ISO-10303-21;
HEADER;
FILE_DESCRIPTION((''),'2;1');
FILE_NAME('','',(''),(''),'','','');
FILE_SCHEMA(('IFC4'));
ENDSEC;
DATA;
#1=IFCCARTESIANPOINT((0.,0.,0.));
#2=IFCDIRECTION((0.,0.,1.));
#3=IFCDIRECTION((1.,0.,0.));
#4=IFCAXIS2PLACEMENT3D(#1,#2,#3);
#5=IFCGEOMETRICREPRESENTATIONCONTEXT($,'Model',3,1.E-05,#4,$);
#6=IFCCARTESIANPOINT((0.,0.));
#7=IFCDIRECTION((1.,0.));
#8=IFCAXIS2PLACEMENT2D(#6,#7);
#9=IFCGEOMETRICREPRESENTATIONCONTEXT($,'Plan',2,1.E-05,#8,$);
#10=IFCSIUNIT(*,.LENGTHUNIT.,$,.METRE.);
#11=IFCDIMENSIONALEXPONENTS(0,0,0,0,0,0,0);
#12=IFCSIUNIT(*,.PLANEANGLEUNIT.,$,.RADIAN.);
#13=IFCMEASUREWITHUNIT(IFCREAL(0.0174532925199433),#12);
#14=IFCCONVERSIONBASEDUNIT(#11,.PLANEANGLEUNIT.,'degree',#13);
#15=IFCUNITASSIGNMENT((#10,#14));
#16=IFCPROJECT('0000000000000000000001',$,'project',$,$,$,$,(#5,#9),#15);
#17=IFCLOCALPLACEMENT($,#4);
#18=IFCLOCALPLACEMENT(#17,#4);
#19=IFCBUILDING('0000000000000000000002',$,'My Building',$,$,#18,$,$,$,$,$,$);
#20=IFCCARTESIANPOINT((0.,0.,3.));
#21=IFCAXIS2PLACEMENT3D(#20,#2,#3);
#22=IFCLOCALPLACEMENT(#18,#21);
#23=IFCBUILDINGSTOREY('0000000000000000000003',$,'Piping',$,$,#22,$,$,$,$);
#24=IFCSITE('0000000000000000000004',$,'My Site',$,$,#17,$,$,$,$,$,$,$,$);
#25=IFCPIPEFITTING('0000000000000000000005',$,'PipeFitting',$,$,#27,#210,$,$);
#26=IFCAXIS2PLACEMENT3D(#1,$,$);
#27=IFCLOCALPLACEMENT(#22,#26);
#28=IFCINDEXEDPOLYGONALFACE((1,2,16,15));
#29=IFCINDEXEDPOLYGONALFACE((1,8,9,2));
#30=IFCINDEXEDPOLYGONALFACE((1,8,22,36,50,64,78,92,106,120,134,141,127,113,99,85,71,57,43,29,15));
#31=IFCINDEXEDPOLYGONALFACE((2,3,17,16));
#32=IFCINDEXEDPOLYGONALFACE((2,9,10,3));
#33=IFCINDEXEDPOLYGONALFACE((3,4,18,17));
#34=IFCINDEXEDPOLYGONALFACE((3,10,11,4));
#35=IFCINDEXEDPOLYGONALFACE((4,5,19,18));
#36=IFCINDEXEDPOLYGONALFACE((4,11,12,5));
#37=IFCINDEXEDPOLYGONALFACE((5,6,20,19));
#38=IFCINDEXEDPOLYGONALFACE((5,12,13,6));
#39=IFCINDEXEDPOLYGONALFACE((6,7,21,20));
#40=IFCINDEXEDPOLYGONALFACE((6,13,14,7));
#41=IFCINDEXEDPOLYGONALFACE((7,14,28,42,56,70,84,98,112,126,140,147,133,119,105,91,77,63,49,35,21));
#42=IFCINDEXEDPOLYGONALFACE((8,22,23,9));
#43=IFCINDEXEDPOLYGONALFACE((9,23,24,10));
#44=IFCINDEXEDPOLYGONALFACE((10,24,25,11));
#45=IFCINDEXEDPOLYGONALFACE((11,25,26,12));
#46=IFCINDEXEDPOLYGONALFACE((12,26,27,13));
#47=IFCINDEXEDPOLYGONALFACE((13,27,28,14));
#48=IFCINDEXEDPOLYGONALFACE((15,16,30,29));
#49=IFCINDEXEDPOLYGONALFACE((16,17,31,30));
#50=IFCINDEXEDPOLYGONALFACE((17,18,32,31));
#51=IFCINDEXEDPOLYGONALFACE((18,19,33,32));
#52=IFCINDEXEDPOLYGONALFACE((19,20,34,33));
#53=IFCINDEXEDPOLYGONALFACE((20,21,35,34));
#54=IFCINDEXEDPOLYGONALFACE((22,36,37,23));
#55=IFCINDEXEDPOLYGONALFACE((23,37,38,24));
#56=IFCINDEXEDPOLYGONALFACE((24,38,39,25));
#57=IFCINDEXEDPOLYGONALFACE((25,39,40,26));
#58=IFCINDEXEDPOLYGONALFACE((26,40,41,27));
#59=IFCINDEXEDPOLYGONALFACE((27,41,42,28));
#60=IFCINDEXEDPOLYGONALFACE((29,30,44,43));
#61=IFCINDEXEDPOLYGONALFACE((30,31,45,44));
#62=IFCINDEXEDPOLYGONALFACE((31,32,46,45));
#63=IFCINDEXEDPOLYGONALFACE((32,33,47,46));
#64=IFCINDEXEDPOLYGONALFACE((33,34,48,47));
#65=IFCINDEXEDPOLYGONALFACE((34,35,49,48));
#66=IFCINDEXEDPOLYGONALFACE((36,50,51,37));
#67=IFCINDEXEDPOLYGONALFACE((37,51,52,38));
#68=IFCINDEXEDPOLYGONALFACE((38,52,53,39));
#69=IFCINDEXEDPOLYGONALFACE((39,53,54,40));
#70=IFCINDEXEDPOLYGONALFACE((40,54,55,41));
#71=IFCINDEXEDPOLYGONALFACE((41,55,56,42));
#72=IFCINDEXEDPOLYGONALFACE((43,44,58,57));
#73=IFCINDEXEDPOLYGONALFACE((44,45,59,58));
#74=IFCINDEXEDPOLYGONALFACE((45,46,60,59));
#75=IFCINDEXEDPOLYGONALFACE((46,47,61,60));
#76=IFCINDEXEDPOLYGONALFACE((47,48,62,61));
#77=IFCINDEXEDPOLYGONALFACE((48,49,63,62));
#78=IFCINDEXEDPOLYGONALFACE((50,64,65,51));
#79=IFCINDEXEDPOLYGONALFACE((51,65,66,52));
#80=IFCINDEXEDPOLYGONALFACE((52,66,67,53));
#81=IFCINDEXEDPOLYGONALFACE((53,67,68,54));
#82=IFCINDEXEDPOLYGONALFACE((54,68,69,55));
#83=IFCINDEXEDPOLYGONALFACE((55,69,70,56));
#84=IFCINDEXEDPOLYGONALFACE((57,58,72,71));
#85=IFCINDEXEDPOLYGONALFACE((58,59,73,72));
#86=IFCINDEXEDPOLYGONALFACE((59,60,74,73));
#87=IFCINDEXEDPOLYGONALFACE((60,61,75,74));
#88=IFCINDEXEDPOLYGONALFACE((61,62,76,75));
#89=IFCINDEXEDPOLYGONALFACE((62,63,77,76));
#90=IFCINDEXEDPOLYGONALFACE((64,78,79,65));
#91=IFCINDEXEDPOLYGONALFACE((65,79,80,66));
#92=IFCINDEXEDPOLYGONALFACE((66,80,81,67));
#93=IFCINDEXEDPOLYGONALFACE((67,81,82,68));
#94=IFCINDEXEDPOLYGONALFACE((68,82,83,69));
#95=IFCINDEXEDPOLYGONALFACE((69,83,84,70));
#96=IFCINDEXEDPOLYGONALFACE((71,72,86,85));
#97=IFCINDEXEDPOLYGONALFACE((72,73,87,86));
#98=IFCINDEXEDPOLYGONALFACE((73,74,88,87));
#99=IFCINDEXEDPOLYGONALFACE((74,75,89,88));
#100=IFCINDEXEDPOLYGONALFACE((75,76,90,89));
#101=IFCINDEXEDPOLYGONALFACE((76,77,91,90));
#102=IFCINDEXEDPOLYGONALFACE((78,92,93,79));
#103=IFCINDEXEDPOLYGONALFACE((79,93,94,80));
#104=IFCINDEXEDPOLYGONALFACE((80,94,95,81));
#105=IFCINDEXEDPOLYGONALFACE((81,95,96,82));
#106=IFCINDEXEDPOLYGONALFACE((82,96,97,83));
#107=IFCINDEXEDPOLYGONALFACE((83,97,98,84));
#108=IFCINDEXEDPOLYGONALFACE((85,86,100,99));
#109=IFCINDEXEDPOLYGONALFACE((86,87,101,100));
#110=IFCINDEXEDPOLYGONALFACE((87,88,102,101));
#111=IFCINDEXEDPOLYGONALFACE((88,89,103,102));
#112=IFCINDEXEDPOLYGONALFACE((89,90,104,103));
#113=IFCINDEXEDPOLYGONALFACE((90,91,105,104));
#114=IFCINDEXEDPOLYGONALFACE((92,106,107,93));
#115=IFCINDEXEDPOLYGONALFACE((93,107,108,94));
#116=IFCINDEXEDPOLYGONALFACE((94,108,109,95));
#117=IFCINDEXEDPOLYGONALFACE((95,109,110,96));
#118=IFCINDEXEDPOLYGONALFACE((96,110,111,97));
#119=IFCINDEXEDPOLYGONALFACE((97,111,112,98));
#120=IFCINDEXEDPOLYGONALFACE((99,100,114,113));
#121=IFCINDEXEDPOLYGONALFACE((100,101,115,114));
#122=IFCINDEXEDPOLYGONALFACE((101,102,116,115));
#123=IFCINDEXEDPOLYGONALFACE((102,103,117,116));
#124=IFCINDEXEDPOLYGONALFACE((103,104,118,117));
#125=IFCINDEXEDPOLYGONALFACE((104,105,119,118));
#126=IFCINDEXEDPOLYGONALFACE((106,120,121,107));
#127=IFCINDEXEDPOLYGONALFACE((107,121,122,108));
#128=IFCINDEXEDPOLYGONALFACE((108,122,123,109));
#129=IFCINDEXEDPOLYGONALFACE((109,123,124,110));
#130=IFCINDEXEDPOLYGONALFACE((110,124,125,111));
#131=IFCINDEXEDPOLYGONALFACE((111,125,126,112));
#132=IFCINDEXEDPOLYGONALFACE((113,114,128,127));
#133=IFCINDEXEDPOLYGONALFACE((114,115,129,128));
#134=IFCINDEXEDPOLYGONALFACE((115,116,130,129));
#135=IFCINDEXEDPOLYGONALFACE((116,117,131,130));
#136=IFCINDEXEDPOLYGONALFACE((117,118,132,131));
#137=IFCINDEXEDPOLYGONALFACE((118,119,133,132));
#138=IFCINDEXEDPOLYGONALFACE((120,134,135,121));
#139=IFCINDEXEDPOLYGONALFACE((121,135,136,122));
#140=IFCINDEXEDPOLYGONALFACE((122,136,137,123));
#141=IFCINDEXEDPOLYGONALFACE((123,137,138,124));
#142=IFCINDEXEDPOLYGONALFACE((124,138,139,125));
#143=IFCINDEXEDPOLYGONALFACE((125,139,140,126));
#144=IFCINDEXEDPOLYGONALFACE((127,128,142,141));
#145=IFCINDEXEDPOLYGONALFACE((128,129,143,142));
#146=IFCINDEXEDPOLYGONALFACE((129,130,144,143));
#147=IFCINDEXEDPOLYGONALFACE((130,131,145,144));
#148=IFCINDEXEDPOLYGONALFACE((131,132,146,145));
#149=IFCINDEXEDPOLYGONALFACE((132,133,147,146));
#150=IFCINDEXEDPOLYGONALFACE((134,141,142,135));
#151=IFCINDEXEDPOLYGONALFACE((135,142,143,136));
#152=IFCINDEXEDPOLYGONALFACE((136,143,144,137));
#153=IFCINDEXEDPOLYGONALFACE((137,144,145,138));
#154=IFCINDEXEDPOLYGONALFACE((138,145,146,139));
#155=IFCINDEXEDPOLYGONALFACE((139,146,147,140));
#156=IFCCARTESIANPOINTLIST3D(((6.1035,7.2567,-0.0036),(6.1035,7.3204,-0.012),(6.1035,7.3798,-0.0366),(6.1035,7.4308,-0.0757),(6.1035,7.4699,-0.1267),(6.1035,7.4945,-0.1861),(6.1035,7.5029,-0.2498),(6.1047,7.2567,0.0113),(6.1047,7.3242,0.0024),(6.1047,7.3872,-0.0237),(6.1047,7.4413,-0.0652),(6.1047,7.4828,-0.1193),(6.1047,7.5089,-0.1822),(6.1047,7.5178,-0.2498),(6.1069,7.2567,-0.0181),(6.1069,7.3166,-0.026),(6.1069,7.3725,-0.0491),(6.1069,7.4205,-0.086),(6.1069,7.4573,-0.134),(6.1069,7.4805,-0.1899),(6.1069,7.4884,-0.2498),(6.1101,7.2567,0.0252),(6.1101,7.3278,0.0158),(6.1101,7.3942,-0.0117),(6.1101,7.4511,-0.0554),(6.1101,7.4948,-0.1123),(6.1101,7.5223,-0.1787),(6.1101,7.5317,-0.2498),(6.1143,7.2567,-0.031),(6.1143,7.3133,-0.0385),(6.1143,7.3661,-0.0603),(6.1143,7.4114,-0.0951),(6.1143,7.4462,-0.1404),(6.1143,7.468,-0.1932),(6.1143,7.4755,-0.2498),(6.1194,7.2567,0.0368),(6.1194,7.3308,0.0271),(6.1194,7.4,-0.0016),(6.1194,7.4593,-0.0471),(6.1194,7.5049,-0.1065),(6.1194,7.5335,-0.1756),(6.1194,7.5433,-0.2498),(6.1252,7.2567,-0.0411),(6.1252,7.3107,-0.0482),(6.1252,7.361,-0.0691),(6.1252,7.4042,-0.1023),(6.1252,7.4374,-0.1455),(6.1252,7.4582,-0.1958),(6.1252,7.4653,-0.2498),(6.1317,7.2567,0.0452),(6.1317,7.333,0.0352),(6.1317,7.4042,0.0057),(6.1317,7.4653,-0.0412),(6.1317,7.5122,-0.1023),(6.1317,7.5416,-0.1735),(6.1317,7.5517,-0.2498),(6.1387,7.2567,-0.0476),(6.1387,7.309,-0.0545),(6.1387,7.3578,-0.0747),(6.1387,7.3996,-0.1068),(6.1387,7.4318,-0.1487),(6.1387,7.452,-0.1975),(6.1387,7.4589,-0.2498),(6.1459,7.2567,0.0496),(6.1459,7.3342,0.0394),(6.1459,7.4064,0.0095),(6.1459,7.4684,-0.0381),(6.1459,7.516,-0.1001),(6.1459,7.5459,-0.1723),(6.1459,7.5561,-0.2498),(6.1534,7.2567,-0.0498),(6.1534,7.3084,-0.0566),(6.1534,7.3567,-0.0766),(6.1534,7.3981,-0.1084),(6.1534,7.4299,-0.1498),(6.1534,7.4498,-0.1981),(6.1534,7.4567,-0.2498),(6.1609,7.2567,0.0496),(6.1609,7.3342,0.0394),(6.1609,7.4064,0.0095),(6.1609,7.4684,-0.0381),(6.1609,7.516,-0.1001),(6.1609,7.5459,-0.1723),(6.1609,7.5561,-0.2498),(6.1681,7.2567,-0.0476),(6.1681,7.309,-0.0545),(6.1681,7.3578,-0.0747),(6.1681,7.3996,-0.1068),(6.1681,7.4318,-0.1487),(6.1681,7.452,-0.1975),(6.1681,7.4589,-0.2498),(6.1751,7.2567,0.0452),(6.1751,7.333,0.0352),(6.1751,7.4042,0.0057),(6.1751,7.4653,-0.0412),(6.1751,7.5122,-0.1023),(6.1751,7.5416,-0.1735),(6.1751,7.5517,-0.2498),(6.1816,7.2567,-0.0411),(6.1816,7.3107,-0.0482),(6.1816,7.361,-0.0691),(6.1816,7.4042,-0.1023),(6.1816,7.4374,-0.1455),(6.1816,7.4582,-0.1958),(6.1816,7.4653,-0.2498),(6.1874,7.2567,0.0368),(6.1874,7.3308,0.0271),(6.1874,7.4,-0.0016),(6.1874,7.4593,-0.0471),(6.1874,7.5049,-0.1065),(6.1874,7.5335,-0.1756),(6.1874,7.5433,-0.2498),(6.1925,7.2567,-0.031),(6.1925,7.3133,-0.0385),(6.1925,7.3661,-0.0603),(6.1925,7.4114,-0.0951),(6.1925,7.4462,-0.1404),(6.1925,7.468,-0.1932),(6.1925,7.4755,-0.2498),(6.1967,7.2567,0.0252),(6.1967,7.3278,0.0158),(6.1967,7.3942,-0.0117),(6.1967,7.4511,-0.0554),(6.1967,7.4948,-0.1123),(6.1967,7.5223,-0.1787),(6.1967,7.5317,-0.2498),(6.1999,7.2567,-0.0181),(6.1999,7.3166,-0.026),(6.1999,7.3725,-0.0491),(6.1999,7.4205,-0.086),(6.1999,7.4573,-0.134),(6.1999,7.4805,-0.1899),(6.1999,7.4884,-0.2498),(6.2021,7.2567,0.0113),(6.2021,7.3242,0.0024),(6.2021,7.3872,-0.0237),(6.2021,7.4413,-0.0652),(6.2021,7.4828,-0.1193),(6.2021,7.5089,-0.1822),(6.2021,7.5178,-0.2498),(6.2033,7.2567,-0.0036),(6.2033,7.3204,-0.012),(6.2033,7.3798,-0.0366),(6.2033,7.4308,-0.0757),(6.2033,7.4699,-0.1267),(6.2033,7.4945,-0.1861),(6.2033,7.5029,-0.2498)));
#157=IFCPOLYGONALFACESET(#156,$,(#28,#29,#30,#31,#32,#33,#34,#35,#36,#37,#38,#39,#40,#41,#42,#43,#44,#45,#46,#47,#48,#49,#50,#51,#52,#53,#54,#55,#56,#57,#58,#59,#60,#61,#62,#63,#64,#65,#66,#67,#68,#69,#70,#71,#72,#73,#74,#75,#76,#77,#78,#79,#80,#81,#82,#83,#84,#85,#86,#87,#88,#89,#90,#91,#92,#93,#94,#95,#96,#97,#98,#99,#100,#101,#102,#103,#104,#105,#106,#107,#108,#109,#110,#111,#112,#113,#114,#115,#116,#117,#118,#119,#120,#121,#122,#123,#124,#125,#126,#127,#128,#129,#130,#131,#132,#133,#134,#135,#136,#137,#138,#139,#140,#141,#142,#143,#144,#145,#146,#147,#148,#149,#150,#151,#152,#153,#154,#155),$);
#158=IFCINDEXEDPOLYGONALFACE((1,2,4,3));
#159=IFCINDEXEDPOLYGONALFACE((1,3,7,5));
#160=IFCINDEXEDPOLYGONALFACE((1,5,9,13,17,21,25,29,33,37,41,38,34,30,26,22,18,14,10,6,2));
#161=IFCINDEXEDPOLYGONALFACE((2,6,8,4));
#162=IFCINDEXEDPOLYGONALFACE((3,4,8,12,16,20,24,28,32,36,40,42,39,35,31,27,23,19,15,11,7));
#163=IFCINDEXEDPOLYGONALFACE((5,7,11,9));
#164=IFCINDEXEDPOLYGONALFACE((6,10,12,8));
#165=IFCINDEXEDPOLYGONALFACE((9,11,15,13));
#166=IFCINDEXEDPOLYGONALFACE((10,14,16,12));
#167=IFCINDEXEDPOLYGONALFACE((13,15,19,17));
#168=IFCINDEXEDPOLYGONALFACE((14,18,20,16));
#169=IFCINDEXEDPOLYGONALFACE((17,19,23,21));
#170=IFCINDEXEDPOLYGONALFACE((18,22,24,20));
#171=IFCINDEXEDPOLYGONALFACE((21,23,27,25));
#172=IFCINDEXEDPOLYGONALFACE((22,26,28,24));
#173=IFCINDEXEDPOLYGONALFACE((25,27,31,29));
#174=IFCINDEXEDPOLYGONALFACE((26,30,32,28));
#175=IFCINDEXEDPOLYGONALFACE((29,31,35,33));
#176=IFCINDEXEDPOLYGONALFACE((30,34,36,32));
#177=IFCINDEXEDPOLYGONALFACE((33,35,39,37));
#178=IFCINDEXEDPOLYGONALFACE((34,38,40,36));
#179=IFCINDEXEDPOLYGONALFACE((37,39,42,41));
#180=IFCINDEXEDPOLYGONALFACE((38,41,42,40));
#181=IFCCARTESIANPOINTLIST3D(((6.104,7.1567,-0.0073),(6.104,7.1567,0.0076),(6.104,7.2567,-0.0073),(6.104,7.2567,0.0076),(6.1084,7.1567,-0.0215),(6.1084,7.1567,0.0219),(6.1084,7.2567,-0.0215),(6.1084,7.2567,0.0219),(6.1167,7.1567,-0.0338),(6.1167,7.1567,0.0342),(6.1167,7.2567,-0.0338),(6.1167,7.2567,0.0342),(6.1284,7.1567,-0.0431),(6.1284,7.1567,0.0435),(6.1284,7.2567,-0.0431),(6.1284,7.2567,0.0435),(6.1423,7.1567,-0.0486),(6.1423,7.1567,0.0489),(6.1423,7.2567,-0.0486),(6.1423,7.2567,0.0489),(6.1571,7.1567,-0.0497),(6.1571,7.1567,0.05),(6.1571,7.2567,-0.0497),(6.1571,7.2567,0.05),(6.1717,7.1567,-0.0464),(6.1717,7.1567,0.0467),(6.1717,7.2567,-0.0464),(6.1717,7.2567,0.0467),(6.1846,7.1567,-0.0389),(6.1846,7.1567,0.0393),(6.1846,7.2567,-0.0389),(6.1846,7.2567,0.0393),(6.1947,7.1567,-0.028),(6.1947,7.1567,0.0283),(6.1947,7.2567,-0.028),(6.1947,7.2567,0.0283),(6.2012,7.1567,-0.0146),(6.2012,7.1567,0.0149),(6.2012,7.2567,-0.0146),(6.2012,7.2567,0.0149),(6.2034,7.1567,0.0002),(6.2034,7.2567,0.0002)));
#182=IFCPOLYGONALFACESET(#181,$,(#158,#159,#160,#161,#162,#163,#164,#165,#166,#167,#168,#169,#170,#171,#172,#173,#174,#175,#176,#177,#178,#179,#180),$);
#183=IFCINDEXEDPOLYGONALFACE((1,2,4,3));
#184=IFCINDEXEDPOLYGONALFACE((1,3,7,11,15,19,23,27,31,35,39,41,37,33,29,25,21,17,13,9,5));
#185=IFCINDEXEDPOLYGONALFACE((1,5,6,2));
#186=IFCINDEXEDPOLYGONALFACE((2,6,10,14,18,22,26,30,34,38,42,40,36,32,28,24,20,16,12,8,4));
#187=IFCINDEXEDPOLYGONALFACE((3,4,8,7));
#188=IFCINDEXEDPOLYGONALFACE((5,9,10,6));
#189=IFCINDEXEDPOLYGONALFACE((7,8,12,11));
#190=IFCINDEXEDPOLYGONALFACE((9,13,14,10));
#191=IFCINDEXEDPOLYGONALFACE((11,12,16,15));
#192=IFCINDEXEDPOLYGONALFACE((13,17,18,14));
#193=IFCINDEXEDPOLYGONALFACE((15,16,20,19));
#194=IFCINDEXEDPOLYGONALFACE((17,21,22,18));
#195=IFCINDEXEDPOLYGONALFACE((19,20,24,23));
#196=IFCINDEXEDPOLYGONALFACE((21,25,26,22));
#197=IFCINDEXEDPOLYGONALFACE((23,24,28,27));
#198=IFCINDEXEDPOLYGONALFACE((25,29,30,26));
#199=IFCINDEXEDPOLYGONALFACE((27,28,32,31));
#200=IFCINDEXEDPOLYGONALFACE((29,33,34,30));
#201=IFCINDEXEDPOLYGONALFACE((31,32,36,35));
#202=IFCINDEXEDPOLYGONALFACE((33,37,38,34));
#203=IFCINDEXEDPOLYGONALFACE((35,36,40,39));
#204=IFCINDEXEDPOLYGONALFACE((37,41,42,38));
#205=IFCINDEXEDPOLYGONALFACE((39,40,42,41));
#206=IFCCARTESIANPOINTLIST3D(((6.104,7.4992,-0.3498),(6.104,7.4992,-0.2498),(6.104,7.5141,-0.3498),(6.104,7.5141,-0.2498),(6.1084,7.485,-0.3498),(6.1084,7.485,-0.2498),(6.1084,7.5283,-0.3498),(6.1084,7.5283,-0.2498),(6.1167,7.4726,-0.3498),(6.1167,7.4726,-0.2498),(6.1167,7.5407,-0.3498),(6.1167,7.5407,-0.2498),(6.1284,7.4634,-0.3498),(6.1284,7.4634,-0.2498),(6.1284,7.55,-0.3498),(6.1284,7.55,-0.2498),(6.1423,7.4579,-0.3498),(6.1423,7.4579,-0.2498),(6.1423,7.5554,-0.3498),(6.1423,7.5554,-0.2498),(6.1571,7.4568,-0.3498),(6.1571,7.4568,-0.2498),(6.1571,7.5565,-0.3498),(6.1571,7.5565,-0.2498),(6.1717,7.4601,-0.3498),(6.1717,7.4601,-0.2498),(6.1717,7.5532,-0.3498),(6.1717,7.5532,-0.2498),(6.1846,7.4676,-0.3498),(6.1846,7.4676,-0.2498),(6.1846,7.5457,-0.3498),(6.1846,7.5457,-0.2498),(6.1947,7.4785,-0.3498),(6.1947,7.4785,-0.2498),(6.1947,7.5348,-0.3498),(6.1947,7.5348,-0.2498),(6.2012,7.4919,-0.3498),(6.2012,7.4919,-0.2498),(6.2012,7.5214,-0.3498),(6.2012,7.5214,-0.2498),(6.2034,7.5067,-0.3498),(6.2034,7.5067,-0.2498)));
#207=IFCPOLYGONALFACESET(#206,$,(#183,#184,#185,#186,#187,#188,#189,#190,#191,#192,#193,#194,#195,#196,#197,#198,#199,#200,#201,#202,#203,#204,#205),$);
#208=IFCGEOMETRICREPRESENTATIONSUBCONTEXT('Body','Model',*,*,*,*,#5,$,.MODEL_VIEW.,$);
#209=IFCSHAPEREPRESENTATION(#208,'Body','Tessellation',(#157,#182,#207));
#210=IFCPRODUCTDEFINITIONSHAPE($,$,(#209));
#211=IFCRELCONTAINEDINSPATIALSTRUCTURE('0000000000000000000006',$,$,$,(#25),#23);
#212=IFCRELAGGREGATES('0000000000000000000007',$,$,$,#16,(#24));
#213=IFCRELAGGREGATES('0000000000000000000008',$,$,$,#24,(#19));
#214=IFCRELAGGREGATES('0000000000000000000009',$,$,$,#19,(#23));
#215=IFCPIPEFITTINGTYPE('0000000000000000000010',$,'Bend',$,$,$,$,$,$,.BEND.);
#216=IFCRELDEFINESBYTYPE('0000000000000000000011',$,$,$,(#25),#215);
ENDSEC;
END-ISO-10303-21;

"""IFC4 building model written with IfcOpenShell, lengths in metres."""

from ifc_helpers import new_model, entity, si_unit, converted_unit, frame, origin_with_axes, origin_2d_with_axis, place, context, subcontext, project, spatial, circle, extrude, source, transform, mapped, type_object, type_shapes, element, save


model = new_model("IFC4")

# Units and contexts
model_context = context("Model", 3, precision=1e-05, world=origin_with_axes())
plan_context = context("Plan", 2, precision=1e-05, world=origin_2d_with_axis())
body_context = subcontext(model_context, "Body", "Model", "MODEL_VIEW")
ifc_project = project(units=[si_unit("LENGTHUNIT", "METRE"), converted_unit("PLANEANGLEUNIT", "degree", entity("IfcReal", 0.0174532925199433), si_unit("PLANEANGLEUNIT", "RADIAN"), dimensions=[0, 0, 0, 0, 0, 0, 0])], contexts=[model_context, plan_context])

# Site, building, storey
site_placement = place(None, origin_with_axes())
site = spatial("IfcSite", under=ifc_project, at=site_placement, Name="My Site")
building_placement = place(site_placement, origin_with_axes())
building = spatial("IfcBuilding", under=site, at=building_placement, Name="My Building")
storey_placement = place(building_placement, frame((0.0, 0.0, 3.0), z_axis=(0.0, 0.0, 1.0), x_axis=(1.0, 0.0, 0.0)))
storey = spatial("IfcBuildingStorey", under=building, at=storey_placement, Name="Piping")

# Pipe fitting
pipe_fitting_type = type_object("IfcPipeFittingType", Name="Bend", PredefinedType="BEND")
shared_shape = source(origin_with_axes(), body_context, "Body", "SolidModel", [
    entity("IfcSweptDiskSolid", entity("IfcIndexedPolyCurve", entity("IfcCartesianPointList3D", [[0.0, 0.0, -0.1], [0.0, -0.0732, -0.2768], [0.0, -0.25, -0.35]]), [entity("IfcArcIndex", [1, 2, 3])]), 0.05),
    extrude(circle(Radius=0.05), origin_with_axes(), (0.0, 0.0, -1.0), 0.1),
    extrude(circle(Radius=0.05), frame((0.0, -0.25, -0.35), z_axis=(0.0, -1.0, 0.0), x_axis=(1.0, 0.0, 0.0)), (0.0, 0.0, 1.0), 0.1),
])
type_shapes(pipe_fitting_type, [shared_shape])
for number, where, z_axis, x_axis, name in (
    (1, (6.1534, 7.1567, 0.0002), (0.0, -1.0, 0.0), (1.0, 0.0, 0.0), "PipeFitting"),
):
    element("IfcPipeFitting", number, at=place(storey_placement, frame(where, z_axis=z_axis, x_axis=x_axis)), inside=storey, type_object=pipe_fitting_type, Name=name, context=body_context, shape_type="MappedRepresentation", body=[
        mapped(shared_shape, transform((0.0, 0.0, 0.0), x_axis=(1.0, 0.0, 0.0), y_axis=(0.0, 1.0, 0.0), z_axis=(0.0, 0.0, 1.0), scale=1.0)),
    ])

save(model, "model.ifc")
